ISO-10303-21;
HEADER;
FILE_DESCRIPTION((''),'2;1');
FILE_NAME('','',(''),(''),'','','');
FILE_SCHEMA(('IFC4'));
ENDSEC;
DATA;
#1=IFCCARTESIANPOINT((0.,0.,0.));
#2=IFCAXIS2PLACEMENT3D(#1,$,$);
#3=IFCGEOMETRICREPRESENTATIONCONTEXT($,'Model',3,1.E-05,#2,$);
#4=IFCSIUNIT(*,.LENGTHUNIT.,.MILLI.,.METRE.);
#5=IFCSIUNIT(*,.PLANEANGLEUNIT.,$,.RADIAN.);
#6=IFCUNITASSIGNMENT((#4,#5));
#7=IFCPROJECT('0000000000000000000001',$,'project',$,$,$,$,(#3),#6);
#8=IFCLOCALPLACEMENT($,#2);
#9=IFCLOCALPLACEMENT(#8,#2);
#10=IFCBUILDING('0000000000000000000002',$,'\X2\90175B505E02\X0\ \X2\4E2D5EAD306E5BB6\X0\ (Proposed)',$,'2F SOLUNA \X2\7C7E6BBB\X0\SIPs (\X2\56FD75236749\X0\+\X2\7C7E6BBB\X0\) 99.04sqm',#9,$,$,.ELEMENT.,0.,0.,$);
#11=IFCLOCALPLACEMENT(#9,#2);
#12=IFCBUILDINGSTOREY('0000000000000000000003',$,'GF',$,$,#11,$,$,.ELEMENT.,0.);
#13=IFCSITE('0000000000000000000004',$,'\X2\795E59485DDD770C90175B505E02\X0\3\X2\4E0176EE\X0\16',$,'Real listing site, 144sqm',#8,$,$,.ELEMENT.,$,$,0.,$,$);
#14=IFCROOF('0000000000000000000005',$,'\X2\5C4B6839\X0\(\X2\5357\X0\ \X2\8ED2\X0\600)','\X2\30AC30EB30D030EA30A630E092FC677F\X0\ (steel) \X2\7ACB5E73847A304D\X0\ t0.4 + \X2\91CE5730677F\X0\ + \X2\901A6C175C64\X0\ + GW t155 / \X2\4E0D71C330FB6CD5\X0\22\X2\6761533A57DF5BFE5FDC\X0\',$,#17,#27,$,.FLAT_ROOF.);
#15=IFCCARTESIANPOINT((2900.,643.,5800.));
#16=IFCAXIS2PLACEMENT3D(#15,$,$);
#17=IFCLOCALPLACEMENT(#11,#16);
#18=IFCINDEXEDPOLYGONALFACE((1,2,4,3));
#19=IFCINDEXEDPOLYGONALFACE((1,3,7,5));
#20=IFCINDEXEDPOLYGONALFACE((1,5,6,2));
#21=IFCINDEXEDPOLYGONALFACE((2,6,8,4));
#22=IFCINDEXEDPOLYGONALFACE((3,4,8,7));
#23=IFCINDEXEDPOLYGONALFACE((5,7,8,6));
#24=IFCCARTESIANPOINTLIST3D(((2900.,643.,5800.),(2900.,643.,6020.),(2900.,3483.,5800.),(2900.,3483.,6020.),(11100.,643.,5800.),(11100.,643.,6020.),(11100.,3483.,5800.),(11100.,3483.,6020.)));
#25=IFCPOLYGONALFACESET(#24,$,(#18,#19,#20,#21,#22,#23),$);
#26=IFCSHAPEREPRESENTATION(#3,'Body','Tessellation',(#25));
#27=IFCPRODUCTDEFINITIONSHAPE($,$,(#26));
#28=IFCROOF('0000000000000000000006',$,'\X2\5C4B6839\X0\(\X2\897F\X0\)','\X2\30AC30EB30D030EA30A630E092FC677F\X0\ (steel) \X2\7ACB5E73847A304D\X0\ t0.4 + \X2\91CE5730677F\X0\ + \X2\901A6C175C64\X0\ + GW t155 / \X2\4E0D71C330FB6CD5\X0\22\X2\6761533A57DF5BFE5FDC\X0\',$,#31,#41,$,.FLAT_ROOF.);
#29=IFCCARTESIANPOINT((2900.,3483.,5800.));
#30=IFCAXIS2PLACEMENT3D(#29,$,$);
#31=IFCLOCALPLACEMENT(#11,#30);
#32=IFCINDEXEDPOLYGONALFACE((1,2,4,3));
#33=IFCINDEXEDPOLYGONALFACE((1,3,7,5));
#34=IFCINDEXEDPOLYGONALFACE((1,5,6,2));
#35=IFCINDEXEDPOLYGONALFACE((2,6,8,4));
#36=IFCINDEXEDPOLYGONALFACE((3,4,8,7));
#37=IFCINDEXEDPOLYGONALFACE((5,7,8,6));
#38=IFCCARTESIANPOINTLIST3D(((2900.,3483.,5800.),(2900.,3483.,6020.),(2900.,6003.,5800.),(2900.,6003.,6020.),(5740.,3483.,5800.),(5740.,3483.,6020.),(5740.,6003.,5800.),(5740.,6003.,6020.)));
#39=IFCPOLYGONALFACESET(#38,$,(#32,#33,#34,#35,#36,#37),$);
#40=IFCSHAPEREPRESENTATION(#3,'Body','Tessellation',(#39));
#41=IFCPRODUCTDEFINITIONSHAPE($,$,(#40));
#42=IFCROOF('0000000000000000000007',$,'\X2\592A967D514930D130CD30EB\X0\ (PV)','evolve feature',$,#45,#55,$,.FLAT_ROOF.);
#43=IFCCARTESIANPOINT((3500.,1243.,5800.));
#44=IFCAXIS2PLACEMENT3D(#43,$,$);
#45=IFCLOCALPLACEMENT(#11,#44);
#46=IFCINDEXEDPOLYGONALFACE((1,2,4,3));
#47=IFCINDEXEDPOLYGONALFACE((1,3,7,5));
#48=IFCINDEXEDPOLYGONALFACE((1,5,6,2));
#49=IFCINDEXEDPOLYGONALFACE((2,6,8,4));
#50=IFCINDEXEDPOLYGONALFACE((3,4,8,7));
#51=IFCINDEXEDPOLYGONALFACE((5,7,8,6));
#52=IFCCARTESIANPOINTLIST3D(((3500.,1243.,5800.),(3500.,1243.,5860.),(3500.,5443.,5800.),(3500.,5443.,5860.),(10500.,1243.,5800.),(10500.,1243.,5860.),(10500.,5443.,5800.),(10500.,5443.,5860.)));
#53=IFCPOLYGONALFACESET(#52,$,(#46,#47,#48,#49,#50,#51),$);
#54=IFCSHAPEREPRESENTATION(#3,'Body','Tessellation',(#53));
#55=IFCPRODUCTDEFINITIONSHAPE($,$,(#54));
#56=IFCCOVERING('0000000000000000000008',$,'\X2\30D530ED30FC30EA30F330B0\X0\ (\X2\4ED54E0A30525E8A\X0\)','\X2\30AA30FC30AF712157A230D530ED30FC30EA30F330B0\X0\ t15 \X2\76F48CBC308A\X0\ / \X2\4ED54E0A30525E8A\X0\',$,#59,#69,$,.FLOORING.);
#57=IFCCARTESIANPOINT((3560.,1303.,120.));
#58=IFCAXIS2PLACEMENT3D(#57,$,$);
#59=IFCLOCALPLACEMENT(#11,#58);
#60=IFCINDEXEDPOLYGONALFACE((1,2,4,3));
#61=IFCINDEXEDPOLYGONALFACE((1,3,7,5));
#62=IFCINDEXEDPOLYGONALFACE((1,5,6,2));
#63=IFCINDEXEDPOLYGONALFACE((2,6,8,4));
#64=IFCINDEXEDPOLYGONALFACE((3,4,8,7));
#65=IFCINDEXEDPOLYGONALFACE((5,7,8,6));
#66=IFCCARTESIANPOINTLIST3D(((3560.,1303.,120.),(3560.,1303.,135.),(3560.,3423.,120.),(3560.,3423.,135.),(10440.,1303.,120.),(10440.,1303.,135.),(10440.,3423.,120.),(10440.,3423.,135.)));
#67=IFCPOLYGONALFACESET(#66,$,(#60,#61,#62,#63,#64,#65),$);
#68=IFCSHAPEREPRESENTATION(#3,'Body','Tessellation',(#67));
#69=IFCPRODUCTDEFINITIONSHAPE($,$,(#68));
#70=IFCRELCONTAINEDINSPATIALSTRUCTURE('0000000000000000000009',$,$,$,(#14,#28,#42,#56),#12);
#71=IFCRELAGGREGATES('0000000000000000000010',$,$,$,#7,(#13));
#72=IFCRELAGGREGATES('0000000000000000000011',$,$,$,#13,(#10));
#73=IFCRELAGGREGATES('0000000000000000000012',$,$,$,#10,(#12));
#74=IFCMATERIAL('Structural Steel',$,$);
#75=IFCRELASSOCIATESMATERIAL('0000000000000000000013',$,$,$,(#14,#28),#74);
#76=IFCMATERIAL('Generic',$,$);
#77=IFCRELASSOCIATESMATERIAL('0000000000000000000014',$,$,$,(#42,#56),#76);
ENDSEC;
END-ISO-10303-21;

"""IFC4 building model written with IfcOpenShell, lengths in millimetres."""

from ifc_helpers import new_model, si_unit, frame, frame_2d, origin, place, context, project, spatial, rectangle, extrude, material, element, save


model = new_model("IFC4")

# Units and contexts
model_context = context("Model", 3, precision=1e-05, world=origin())
ifc_project = project(units=[si_unit("LENGTHUNIT", "METRE", prefix="MILLI"), si_unit("PLANEANGLEUNIT", "RADIAN")], contexts=[model_context])

# Site, building, storey
site_placement = place(None, origin())
site = spatial("IfcSite", under=ifc_project, at=site_placement, Name="神奈川県逗子市3丁目16", ObjectType="Real listing site, 144sqm", CompositionType="ELEMENT", RefElevation=0.0)
building_placement = place(site_placement, origin())
building = spatial("IfcBuilding", under=site, at=building_placement, Name="逗子市 中庭の家 (Proposed)", ObjectType="2F SOLUNA 籾殻SIPs (国産杉+籾殻) 99.04sqm", CompositionType="ELEMENT", ElevationOfRefHeight=0.0, ElevationOfTerrain=0.0)
storey_placement = place(building_placement, origin())
storey = spatial("IfcBuildingStorey", under=building, at=storey_placement, Name="GF", CompositionType="ELEMENT", Elevation=0.0)

# Shared definitions
ifc_material_1 = material(Name="Generic")

# Roofs
ifc_material_2 = material(Name="Structural Steel")
roof_1_placement = place(storey_placement, frame((2900.0, 643.0, 5800.0)))
element("IfcRoof", 1, at=roof_1_placement, inside=storey, material=ifc_material_2, Name="屋根(南 軒600)", Description="ガルバリウム鋼板 (steel) 立平葺き t0.4 + 野地板 + 通気層 + GW t155 / 不燃・法22条区域対応", PredefinedType="FLAT_ROOF", context=model_context, shape_type="SweptSolid", body=[
    extrude(rectangle(XDim=8200.0, YDim=2840.0, at=frame_2d((4100.0, 1420.0))), frame((2900.0, 643.0, 5800.0)), (0.0, 0.0, 1.0), 220.0),
])
roof_2_placement = place(storey_placement, frame((2900.0, 3483.0, 5800.0)))
element("IfcRoof", 2, at=roof_2_placement, inside=storey, material=ifc_material_2, Name="屋根(西)", Description="ガルバリウム鋼板 (steel) 立平葺き t0.4 + 野地板 + 通気層 + GW t155 / 不燃・法22条区域対応", PredefinedType="FLAT_ROOF", context=model_context, shape_type="SweptSolid", body=[
    extrude(rectangle(XDim=2840.0, YDim=2520.0, at=frame_2d((1420.0, 1260.0))), frame((2900.0, 3483.0, 5800.0)), (0.0, 0.0, 1.0), 220.0),
])
roof_3_placement = place(storey_placement, frame((3500.0, 1243.0, 5800.0)))
element("IfcRoof", 3, at=roof_3_placement, inside=storey, material=ifc_material_1, Name="太陽光パネル (PV)", Description="evolve feature", PredefinedType="FLAT_ROOF", context=model_context, shape_type="SweptSolid", body=[
    extrude(rectangle(XDim=7000.0, YDim=4200.0, at=frame_2d((3500.0, 2100.0))), frame((3500.0, 1243.0, 5800.0)), (0.0, 0.0, 1.0), 60.0),
])

# Covering
covering_placement = place(storey_placement, frame((3560.0, 1303.0, 120.0)))
element("IfcCovering", 4, at=covering_placement, inside=storey, material=ifc_material_1, Name="フローリング (仕上げ床)", Description="オーク無垢フローリング t15 直貼り / 仕上げ床", PredefinedType="FLOORING", context=model_context, shape_type="SweptSolid", body=[
    extrude(rectangle(XDim=6880.0, YDim=2120.0, at=frame_2d((3440.0, 1060.0))), frame((3560.0, 1303.0, 120.0)), (0.0, 0.0, 1.0), 15.0),
])

save(model, "model.ifc")
